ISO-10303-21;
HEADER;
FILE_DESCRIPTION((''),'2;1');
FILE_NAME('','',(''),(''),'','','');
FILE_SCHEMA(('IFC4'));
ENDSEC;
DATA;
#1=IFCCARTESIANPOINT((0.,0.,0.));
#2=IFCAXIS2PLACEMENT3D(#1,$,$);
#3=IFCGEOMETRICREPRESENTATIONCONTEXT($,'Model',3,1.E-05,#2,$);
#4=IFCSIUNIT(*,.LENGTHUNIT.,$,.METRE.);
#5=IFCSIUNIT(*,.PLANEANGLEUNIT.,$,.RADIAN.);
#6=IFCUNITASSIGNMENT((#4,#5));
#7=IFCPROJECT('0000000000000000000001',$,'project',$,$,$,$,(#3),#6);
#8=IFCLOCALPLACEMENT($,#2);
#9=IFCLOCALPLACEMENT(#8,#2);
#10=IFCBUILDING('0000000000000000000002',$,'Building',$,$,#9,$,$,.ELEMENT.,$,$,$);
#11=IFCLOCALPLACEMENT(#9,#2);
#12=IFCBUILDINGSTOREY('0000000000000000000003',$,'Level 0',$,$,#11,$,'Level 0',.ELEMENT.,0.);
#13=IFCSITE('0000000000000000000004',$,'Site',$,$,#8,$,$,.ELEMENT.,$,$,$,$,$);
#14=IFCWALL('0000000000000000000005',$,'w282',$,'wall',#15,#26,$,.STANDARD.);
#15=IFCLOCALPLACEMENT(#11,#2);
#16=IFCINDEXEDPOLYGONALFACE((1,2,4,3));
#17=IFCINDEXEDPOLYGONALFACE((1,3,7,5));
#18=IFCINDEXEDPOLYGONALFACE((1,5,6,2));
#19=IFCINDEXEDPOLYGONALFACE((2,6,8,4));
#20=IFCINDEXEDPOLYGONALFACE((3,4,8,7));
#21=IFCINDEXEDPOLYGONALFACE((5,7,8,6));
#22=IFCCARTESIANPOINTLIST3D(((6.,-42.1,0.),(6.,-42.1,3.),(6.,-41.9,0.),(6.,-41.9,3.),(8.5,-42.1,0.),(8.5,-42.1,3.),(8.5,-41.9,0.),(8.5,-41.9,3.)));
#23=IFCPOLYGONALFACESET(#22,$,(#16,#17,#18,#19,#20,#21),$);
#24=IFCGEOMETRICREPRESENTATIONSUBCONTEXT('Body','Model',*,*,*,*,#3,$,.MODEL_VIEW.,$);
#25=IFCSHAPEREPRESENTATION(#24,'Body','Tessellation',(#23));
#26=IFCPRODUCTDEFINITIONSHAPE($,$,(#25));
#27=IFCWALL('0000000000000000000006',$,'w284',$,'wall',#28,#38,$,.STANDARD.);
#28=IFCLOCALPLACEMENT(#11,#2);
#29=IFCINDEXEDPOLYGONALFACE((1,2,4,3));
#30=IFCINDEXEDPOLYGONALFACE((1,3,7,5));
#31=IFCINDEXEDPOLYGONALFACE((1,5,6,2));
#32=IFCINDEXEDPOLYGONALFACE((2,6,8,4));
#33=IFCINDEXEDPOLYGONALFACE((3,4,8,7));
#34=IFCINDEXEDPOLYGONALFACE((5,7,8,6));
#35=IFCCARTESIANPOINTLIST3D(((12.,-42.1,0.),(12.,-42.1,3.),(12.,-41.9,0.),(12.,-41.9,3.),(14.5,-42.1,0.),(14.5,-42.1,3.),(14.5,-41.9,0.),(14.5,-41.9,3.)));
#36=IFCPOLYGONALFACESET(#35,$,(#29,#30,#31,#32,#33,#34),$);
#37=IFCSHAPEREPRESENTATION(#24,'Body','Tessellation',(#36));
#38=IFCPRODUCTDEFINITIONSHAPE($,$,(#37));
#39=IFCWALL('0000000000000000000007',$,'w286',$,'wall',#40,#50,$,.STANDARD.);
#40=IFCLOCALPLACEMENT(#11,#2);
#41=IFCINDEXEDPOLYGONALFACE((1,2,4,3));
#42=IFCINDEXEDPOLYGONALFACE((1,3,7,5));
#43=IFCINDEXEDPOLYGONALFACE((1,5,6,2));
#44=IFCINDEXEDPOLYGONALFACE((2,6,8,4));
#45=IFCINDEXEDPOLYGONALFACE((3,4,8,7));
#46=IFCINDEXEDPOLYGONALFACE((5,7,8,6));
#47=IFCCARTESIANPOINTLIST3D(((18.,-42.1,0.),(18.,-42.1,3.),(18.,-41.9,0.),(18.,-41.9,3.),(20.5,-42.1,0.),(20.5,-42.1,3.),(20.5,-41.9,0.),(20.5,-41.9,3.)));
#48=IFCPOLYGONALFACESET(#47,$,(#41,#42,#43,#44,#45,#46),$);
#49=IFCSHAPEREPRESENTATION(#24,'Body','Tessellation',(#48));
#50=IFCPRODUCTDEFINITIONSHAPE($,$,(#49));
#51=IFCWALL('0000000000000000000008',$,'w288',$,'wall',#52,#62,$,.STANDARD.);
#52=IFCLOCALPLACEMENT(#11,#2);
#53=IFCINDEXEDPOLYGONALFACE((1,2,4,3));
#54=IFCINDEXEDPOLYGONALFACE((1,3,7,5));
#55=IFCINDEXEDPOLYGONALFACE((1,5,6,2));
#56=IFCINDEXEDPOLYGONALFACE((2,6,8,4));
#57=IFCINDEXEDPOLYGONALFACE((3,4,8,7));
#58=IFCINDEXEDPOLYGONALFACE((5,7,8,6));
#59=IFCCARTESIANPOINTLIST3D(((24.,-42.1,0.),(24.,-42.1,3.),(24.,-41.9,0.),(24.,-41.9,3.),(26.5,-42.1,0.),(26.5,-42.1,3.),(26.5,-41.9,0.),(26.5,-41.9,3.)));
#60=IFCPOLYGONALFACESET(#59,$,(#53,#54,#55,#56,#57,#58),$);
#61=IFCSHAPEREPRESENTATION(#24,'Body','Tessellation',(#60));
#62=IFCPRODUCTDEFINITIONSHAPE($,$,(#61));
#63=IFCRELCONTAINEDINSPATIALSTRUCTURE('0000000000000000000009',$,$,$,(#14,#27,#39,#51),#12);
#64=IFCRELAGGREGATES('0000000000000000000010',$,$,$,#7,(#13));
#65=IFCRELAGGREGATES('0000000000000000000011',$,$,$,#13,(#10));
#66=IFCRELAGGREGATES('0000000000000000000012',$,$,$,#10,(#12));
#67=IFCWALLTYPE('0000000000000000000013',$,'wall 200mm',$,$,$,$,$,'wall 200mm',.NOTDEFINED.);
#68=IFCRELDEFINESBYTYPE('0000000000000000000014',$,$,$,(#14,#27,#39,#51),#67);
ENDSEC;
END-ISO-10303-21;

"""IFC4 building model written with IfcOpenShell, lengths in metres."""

from ifc_helpers import new_model, si_unit, frame, frame_2d, origin, place, context, subcontext, project, spatial, rectangle, extrude, type_object, element, save


model = new_model("IFC4")

# Units and contexts
model_context = context("Model", 3, precision=1e-05, world=origin())
body_context = subcontext(model_context, "Body", "Model", "MODEL_VIEW")
ifc_project = project(units=[si_unit("LENGTHUNIT", "METRE"), si_unit("PLANEANGLEUNIT", "RADIAN")], contexts=[model_context])

# Site, building, storey
site_placement = place(None, origin())
site = spatial("IfcSite", under=ifc_project, at=site_placement, Name="Site", CompositionType="ELEMENT")
building_placement = place(site_placement, origin())
building = spatial("IfcBuilding", under=site, at=building_placement, Name="Building", CompositionType="ELEMENT")
storey_placement = place(building_placement, origin())
storey = spatial("IfcBuildingStorey", under=building, at=storey_placement, Name="Level 0", LongName="Level 0", CompositionType="ELEMENT", Elevation=0.0)

# Walls
wall_type = type_object("IfcWallType", Name="wall 200mm", ElementType="wall 200mm", PredefinedType="NOTDEFINED")
for number, where, z_axis, x_axis, name in (
    (1, (6.0, -42.0, 0.0), (0.0, 0.0, 1.0), (1.0, 0.0, 0.0), "w282"),
    (2, (12.0, -42.0, 0.0), (0.0, 0.0, 1.0), (1.0, 0.0, 0.0), "w284"),
    (3, (18.0, -42.0, 0.0), (0.0, 0.0, 1.0), (1.0, 0.0, 0.0), "w286"),
    (4, (24.0, -42.0, 0.0), (0.0, 0.0, 1.0), (1.0, 0.0, 0.0), "w288"),
):
    element("IfcWall", number, at=place(storey_placement, frame(where, z_axis=z_axis, x_axis=x_axis)), inside=storey, type_object=wall_type, Name=name, ObjectType="wall", PredefinedType="STANDARD", context=body_context, shape_type="SweptSolid", body=[
        extrude(rectangle(XDim=2.5, YDim=0.2, at=frame_2d((1.25, 0.0))), origin(), (0.0, 0.0, 1.0), 3.0),
    ])

save(model, "model.ifc")
